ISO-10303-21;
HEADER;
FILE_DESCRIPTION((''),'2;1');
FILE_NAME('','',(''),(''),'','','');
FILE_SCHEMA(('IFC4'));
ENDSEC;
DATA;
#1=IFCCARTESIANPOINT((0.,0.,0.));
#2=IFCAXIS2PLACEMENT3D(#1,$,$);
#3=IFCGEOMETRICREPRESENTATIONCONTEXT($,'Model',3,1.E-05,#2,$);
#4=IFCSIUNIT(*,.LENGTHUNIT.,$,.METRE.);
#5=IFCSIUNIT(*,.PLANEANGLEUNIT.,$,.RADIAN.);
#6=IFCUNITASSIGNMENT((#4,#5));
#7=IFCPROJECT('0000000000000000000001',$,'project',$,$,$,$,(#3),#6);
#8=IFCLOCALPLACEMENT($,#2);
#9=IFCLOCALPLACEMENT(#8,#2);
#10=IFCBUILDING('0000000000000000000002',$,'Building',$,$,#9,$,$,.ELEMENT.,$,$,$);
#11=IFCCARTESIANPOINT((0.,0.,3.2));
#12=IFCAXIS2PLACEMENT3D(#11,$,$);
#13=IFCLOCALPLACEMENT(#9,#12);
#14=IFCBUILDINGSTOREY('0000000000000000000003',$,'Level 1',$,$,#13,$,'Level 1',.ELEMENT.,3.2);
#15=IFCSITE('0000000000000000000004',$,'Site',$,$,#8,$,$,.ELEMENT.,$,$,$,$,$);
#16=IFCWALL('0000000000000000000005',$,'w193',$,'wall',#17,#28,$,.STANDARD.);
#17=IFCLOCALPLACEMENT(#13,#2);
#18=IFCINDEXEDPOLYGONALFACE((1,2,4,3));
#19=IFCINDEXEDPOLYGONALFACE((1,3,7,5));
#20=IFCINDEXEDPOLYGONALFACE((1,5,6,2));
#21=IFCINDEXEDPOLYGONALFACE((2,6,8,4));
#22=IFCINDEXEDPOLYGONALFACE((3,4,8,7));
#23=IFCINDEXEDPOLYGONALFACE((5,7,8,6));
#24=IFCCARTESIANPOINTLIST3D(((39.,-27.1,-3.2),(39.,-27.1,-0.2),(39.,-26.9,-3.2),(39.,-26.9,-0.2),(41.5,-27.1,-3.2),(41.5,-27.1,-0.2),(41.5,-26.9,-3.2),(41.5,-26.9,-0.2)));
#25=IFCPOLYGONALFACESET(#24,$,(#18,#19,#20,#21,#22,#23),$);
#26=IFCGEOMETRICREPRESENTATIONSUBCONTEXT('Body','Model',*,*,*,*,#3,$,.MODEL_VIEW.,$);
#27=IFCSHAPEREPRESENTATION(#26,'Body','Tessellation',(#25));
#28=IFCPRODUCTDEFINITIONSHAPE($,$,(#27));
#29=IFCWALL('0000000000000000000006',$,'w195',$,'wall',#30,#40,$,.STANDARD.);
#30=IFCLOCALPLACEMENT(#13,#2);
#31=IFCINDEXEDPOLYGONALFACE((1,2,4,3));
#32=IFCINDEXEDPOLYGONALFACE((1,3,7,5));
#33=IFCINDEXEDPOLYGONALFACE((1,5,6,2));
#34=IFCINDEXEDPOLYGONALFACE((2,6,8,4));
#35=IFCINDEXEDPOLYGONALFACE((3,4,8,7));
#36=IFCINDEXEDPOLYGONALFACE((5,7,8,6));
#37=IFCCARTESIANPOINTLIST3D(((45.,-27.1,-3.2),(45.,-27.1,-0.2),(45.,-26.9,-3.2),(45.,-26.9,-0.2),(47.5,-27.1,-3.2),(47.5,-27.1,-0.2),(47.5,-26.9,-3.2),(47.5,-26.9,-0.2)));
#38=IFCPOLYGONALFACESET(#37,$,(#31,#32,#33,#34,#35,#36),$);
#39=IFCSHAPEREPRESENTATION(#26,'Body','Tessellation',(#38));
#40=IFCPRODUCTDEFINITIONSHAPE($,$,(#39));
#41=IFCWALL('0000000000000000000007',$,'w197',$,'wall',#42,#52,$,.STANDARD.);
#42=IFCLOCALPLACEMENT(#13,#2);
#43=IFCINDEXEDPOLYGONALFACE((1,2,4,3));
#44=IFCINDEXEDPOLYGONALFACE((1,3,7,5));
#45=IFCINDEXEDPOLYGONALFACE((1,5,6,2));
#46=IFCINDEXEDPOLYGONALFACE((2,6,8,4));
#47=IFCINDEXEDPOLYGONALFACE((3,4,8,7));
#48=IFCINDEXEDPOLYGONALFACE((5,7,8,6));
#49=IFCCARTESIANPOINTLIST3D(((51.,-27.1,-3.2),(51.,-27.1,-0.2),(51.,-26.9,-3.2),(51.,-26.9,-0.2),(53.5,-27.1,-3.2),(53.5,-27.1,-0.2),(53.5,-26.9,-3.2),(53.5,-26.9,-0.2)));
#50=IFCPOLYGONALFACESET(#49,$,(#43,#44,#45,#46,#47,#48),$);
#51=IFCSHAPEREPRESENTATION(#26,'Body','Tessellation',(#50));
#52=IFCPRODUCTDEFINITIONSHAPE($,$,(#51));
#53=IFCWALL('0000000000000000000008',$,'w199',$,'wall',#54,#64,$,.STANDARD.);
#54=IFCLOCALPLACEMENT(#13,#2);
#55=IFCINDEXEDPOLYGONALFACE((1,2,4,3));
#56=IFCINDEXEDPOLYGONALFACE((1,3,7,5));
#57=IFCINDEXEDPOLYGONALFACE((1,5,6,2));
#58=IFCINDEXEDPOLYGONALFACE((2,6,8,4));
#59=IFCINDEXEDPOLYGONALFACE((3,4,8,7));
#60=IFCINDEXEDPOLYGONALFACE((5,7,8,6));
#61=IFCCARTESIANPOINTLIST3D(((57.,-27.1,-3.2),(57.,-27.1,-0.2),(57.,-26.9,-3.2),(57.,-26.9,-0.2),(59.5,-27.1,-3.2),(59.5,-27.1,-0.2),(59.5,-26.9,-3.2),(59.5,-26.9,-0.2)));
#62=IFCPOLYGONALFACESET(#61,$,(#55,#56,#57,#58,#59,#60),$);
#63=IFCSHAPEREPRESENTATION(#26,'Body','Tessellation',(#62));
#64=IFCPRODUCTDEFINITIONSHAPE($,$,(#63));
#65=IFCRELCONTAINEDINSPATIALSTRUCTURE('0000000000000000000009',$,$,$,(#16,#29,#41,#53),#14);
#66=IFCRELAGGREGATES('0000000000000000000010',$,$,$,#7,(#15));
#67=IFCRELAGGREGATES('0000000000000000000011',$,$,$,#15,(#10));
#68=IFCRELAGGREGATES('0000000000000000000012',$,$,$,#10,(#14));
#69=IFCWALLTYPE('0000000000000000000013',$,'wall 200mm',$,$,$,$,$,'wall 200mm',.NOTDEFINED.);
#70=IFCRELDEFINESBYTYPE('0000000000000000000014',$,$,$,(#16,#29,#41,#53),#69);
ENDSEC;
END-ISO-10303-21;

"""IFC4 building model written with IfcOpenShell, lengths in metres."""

from ifc_helpers import new_model, si_unit, frame, frame_2d, origin, place, context, subcontext, project, spatial, rectangle, extrude, type_object, element, save


model = new_model("IFC4")

# Units and contexts
model_context = context("Model", 3, precision=1e-05, world=origin())
body_context = subcontext(model_context, "Body", "Model", "MODEL_VIEW")
ifc_project = project(units=[si_unit("LENGTHUNIT", "METRE"), si_unit("PLANEANGLEUNIT", "RADIAN")], contexts=[model_context])

# Site, building, storey
site_placement = place(None, origin())
site = spatial("IfcSite", under=ifc_project, at=site_placement, Name="Site", CompositionType="ELEMENT")
building_placement = place(site_placement, origin())
building = spatial("IfcBuilding", under=site, at=building_placement, Name="Building", CompositionType="ELEMENT")
storey_placement = place(building_placement, frame((0.0, 0.0, 3.2)))
storey = spatial("IfcBuildingStorey", under=building, at=storey_placement, Name="Level 1", LongName="Level 1", CompositionType="ELEMENT", Elevation=3.2)

# Walls
wall_type = type_object("IfcWallType", Name="wall 200mm", ElementType="wall 200mm", PredefinedType="NOTDEFINED")
for number, where, z_axis, x_axis, name in (
    (1, (39.0, -27.0, -3.2), (0.0, 0.0, 1.0), (1.0, 0.0, 0.0), "w193"),
    (2, (45.0, -27.0, -3.2), (0.0, 0.0, 1.0), (1.0, 0.0, 0.0), "w195"),
    (3, (51.0, -27.0, -3.2), (0.0, 0.0, 1.0), (1.0, 0.0, 0.0), "w197"),
    (4, (57.0, -27.0, -3.2), (0.0, 0.0, 1.0), (1.0, 0.0, 0.0), "w199"),
):
    element("IfcWall", number, at=place(storey_placement, frame(where, z_axis=z_axis, x_axis=x_axis)), inside=storey, type_object=wall_type, Name=name, ObjectType="wall", PredefinedType="STANDARD", context=body_context, shape_type="SweptSolid", body=[
        extrude(rectangle(XDim=2.5, YDim=0.2, at=frame_2d((1.25, 0.0))), origin(), (0.0, 0.0, 1.0), 3.0),
    ])

save(model, "model.ifc")
